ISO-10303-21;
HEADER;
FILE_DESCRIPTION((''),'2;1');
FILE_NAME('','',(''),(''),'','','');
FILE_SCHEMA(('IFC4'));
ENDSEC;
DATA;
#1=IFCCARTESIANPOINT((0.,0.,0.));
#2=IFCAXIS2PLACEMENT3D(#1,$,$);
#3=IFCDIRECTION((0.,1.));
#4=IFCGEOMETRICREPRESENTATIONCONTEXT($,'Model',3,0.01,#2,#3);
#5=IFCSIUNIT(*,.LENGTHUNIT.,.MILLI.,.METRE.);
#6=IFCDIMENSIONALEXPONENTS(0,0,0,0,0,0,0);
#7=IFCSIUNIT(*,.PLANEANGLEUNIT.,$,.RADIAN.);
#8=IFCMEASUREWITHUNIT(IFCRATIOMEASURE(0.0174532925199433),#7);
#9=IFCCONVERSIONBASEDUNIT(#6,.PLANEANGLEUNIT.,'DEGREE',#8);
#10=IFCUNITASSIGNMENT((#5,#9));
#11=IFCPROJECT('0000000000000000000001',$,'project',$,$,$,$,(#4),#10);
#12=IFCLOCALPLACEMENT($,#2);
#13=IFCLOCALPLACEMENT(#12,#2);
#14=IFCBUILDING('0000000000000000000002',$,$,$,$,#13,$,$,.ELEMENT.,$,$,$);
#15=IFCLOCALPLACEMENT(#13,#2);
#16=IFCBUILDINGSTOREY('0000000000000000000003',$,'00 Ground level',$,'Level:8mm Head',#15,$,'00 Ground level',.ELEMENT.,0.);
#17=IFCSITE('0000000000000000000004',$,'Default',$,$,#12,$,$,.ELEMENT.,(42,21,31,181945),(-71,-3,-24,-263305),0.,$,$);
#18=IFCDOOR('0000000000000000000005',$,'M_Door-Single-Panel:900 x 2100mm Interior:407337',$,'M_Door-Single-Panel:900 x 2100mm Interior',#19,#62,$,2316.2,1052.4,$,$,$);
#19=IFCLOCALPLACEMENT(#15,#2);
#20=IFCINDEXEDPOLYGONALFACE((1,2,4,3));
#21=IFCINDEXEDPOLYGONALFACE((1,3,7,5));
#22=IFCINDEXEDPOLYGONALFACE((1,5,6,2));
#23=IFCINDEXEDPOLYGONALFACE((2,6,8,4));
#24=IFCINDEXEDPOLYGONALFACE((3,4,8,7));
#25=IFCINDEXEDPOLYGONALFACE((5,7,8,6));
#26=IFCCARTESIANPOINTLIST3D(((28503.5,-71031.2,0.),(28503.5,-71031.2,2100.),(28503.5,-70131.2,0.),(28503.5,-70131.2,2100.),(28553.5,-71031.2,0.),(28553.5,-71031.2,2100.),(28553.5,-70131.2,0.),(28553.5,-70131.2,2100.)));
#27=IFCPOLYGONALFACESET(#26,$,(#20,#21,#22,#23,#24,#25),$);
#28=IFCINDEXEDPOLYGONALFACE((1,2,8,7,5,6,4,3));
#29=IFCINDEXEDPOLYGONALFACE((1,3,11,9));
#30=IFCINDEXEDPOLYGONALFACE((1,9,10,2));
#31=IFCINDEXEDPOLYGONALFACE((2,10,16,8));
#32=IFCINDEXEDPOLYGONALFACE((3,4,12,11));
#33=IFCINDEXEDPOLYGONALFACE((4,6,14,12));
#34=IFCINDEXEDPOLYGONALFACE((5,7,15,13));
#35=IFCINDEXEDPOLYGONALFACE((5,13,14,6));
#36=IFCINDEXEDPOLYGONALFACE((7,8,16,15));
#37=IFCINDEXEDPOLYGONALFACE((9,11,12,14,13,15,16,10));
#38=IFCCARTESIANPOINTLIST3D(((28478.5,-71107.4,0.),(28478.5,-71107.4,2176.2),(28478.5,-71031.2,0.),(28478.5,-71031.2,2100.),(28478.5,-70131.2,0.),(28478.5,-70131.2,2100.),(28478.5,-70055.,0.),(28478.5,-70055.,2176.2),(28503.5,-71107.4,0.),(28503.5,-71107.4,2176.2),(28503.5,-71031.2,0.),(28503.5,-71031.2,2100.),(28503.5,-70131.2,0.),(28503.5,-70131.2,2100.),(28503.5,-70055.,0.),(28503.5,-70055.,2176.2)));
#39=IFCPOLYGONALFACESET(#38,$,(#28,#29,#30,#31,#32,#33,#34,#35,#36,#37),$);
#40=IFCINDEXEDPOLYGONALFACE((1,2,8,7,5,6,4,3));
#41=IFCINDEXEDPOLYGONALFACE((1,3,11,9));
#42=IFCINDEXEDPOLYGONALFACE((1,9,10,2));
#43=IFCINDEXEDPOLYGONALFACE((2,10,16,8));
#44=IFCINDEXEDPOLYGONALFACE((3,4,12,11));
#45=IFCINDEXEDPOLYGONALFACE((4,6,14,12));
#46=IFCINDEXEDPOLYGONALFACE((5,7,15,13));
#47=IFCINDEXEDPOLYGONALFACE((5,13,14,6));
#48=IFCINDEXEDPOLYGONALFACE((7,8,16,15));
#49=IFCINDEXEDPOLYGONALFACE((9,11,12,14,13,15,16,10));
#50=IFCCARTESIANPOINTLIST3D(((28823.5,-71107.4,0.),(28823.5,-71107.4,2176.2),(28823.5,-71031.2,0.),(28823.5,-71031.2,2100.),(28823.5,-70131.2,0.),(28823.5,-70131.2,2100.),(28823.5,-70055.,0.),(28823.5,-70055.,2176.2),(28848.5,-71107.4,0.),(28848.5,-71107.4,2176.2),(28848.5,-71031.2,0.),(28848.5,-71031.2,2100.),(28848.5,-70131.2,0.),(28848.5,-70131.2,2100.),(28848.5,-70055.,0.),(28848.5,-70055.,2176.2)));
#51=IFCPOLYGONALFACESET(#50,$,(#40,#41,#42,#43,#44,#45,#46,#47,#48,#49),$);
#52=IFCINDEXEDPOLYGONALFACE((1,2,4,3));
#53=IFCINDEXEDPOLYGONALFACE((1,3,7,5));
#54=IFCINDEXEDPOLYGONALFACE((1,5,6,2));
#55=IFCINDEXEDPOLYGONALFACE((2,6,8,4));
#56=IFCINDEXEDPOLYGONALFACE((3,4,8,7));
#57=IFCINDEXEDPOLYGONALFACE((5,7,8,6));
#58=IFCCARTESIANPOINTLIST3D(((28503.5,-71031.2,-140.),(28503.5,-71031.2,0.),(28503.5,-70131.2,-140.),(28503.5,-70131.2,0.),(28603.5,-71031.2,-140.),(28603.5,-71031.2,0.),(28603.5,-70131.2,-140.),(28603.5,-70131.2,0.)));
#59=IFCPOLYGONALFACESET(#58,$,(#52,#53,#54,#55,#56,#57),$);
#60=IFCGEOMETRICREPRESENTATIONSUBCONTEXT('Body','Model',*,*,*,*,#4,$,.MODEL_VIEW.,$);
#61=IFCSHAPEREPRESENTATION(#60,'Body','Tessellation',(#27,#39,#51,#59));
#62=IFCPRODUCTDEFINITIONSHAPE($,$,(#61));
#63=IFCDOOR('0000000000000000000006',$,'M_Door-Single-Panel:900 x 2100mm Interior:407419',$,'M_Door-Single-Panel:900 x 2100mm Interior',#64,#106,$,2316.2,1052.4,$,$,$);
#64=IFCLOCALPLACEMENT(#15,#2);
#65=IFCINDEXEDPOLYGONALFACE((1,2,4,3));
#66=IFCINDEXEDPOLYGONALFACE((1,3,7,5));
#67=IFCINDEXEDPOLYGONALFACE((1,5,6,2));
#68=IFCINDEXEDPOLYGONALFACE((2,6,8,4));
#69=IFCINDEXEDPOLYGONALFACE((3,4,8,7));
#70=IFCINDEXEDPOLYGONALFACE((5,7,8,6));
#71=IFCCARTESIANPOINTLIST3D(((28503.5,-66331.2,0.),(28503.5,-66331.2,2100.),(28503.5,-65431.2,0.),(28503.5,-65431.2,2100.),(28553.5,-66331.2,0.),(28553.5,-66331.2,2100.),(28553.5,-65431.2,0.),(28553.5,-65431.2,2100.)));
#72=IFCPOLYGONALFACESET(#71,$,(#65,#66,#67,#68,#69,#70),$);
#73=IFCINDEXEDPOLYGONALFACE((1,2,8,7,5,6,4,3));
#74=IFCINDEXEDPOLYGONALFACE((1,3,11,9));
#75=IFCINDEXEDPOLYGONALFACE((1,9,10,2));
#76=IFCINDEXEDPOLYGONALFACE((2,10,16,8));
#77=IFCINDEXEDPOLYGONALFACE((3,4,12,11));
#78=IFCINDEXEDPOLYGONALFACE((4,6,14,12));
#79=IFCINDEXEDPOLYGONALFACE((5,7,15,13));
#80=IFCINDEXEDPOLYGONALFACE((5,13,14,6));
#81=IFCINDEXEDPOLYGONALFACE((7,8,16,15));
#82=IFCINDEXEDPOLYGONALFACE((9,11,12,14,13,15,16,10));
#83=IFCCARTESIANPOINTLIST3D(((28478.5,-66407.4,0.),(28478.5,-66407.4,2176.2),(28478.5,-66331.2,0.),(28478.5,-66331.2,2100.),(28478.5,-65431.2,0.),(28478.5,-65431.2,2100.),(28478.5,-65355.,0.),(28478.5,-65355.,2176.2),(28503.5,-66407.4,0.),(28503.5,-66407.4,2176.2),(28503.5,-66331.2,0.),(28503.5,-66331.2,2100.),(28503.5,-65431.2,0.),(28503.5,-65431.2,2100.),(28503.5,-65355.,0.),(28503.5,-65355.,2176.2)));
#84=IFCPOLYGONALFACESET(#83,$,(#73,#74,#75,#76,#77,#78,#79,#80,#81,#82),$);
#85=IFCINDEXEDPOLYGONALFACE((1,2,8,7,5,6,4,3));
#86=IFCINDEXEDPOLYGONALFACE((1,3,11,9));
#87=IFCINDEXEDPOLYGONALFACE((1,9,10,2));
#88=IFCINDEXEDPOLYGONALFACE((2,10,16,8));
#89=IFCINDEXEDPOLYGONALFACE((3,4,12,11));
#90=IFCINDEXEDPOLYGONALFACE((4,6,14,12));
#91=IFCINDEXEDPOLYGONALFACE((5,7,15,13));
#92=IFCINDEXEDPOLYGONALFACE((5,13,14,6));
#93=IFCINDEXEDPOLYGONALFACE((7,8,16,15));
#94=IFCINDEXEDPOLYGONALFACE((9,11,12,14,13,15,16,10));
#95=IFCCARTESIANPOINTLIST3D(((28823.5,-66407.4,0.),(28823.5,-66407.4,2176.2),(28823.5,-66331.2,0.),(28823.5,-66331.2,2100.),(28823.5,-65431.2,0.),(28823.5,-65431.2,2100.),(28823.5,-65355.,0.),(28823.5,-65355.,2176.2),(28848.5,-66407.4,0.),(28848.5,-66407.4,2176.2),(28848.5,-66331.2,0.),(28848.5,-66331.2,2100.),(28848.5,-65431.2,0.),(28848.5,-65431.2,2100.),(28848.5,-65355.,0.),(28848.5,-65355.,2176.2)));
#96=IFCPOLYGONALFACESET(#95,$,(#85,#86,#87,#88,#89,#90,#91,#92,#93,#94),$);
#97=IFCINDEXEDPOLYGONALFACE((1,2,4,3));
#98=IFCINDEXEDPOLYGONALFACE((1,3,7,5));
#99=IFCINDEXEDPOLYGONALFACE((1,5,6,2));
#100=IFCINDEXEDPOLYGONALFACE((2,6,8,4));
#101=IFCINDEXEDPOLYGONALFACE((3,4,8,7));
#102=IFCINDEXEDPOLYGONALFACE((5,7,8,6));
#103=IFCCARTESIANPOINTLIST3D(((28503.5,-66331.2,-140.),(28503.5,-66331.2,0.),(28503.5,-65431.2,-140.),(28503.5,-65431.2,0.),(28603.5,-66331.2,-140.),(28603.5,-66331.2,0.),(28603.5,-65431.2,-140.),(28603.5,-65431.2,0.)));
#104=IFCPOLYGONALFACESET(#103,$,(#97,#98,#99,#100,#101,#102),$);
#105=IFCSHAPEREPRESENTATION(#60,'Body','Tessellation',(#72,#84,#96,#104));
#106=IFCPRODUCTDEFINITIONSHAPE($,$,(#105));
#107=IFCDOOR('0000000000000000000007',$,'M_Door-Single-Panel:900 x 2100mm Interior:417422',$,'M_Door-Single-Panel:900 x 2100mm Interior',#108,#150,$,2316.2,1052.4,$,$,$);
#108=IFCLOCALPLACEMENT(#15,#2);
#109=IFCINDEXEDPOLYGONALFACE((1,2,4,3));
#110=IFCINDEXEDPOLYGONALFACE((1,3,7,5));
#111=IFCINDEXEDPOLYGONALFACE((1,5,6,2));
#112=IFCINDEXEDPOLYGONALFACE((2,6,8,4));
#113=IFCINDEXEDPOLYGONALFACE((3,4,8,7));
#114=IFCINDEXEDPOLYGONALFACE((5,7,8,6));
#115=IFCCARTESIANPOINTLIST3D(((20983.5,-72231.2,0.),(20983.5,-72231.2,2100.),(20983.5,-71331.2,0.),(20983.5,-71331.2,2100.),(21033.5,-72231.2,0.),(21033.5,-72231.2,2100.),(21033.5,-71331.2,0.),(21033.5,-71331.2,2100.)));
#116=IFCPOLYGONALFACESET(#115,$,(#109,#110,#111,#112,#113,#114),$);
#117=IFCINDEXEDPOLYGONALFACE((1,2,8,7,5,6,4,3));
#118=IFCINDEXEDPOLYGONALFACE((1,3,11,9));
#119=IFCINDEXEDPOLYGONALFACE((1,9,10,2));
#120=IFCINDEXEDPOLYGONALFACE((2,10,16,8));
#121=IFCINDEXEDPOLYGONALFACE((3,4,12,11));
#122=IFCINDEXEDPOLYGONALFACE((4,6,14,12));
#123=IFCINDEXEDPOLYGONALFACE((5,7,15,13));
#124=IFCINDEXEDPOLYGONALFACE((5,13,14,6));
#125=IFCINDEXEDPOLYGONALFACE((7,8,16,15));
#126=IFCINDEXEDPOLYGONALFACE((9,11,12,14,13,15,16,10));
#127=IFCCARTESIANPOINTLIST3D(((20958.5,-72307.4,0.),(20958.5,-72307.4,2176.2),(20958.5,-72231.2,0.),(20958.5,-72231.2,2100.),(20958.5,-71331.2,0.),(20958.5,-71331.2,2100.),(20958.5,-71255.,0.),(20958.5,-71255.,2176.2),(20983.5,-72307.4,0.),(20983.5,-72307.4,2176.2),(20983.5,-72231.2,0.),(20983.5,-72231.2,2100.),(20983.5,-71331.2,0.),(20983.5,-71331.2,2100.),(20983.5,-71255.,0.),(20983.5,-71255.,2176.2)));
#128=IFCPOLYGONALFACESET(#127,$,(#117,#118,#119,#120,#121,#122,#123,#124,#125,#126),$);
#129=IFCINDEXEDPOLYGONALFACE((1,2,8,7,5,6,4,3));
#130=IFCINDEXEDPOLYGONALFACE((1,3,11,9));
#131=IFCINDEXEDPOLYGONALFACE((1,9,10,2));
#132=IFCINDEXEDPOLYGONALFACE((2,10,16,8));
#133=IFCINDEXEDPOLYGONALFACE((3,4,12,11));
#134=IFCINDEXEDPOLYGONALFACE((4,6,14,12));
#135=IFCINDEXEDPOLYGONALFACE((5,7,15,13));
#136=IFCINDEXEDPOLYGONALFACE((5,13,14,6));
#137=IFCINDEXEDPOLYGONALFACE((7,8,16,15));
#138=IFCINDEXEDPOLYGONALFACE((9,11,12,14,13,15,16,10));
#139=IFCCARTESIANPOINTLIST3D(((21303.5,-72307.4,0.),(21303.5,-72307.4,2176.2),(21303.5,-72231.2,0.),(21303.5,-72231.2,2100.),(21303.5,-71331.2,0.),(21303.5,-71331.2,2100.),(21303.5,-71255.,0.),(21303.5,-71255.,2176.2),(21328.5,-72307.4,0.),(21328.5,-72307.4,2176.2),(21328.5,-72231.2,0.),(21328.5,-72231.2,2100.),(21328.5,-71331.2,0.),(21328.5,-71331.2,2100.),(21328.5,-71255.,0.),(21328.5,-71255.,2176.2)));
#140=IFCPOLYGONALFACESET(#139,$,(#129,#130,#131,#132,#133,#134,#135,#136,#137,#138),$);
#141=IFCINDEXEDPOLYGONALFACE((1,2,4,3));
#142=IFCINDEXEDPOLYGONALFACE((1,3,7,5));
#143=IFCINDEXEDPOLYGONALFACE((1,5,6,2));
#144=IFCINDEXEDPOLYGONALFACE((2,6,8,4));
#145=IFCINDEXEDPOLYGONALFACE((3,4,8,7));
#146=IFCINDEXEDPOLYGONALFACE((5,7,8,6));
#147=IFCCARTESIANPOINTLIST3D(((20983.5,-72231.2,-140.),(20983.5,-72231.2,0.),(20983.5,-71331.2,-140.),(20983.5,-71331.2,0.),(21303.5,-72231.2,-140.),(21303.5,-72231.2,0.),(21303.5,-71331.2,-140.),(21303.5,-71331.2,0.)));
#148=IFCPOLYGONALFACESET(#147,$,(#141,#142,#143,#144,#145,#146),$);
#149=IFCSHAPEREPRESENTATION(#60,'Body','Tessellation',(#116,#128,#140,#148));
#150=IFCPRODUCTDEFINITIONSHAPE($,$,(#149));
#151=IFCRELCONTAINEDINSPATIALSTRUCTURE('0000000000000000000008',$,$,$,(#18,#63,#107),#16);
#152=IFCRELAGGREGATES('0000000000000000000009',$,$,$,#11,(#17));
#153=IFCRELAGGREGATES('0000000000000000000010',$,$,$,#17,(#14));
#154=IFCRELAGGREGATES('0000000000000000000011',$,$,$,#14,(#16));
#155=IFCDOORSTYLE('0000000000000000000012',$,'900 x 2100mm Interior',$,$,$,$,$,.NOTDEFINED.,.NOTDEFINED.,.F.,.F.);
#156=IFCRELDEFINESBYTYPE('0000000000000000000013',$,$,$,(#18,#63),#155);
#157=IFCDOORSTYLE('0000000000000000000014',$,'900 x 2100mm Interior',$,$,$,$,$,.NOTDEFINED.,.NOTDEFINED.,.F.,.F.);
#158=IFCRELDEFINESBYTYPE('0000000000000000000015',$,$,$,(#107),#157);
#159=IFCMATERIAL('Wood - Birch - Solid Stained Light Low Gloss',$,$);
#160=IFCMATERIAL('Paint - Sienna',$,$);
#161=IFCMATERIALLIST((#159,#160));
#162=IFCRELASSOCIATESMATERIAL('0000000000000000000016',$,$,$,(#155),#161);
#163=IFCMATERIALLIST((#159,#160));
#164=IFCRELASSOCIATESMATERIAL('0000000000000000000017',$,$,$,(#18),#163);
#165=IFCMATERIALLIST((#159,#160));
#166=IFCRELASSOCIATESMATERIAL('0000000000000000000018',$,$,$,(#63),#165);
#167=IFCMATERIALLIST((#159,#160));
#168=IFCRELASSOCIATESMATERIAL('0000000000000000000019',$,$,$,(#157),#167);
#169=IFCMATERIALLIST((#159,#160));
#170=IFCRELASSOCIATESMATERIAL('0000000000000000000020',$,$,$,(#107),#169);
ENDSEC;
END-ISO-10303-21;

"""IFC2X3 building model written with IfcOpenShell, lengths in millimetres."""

from ifc_helpers import new_model, entity, si_unit, converted_unit, direction, frame, frame_2d, origin, origin_2d_with_axis, place, context, subcontext, project, spatial, polyline, rectangle, outline, extrude, source, transform, mapped, material, material_list, type_object, type_shapes, element, save


model = new_model("IFC2X3")

# Units and contexts
model_context = context("Model", 3, precision=0.01, world=origin(), true_north=direction((0.0, 1.0)))
body_context = subcontext(model_context, "Body", "Model", "MODEL_VIEW")
ifc_project = project(units=[si_unit("LENGTHUNIT", "METRE", prefix="MILLI"), converted_unit("PLANEANGLEUNIT", "DEGREE", entity("IfcRatioMeasure", 0.0174532925199433), si_unit("PLANEANGLEUNIT", "RADIAN"), dimensions=[0, 0, 0, 0, 0, 0, 0])], contexts=[model_context])

# Site, building, storey
site_placement = place(None, origin())
site = spatial("IfcSite", under=ifc_project, at=site_placement, Name="Default", CompositionType="ELEMENT", RefLatitude=(42, 21, 31, 181945), RefLongitude=(-71, -3, -24, -263305), RefElevation=0.0)
building_placement = place(site_placement, origin())
building = spatial("IfcBuilding", under=site, at=building_placement, CompositionType="ELEMENT")
storey_placement = place(building_placement, origin())
storey = spatial("IfcBuildingStorey", under=building, at=storey_placement, Name="00 Ground level", ObjectType="Level:8mm Head", LongName="00 Ground level", CompositionType="ELEMENT", Elevation=0.0)

# Doors
ifc_material_1 = material(Name="Wood - Birch - Solid Stained Light Low Gloss")
ifc_material_2 = material(Name="Paint - Sienna")
ifc_material_list_1 = material_list([ifc_material_1, ifc_material_2])
ifc_material_list_2 = material_list([ifc_material_1, ifc_material_2])
door_style_1 = type_object("IfcDoorStyle", Name="900 x 2100mm Interior", ConstructionType="NOTDEFINED", OperationType="NOTDEFINED", ParameterTakesPrecedence=False, Sizeable=False, material=ifc_material_list_2)
shared_shape_1 = source(origin(), body_context, "Body", "SweptSolid", [
    extrude(rectangle(XDim=900.0, YDim=50.0, at=origin_2d_with_axis()), frame((450.0, 295.0, 140.0)), (0.0, 0.0, 1.0), 2100.0),
    extrude(outline(polyline([(-526.2, -1107.2), (526.2, -1107.2), (526.2, 1069.0), (450.0, 1069.0), (450.0, -1031.0), (-450.0, -1031.0), (-450.0, 1069.0), (-526.2, 1069.0), (-526.2, -1107.2)])), frame((450.0, 345.0, 1209.0), z_axis=(0.0, -1.0, 0.0), x_axis=(-1.0, 0.0, 0.0)), (0.0, 0.0, 1.0), 25.0),
    extrude(outline(polyline([(-1107.2, -526.2), (1069.0, -526.2), (1069.0, -450.0), (-1031.0, -450.0), (-1031.0, 450.0), (1069.0, 450.0), (1069.0, 526.2), (-1107.2, 526.2), (-1107.2, -526.2)])), frame((450.0, 0.0, 1209.0), z_axis=(0.0, -1.0, 0.0), x_axis=(0.0, 0.0, -1.0)), (0.0, 0.0, 1.0), 25.0),
    extrude(rectangle(XDim=100.0, YDim=900.0, at=frame_2d((0.0, 0.0), x_axis=(1.0, 0.0))), frame((450.0, 270.0, 0.0), z_axis=(0.0, 0.0, 1.0), x_axis=(0.0, -1.0, 0.0)), (0.0, 0.0, 1.0), 140.0),
])
type_shapes(door_style_1, [shared_shape_1])
door_1_placement = place(storey_placement, frame((28823.5, -71031.2, -140.0), z_axis=(0.0, 0.0, 1.0), x_axis=(0.0, 1.0, 0.0)))
element("IfcDoor", 1, at=door_1_placement, inside=storey, type_object=door_style_1, material=ifc_material_list_1, Name="M_Door-Single-Panel:900 x 2100mm Interior:407337", ObjectType="M_Door-Single-Panel:900 x 2100mm Interior", OverallHeight=2316.2, OverallWidth=1052.4, context=body_context, shape_type="MappedRepresentation", body=[
    mapped(shared_shape_1, transform((0.0, 0.0, 0.0), scale=1.0)),
])
ifc_material_list_3 = material_list([ifc_material_1, ifc_material_2])
door_2_placement = place(storey_placement, frame((28823.5, -66331.2, -140.0), z_axis=(0.0, 0.0, 1.0), x_axis=(0.0, 1.0, 0.0)))
element("IfcDoor", 2, at=door_2_placement, inside=storey, type_object=door_style_1, material=ifc_material_list_3, Name="M_Door-Single-Panel:900 x 2100mm Interior:407419", ObjectType="M_Door-Single-Panel:900 x 2100mm Interior", OverallHeight=2316.2, OverallWidth=1052.4, context=body_context, shape_type="MappedRepresentation", body=[
    mapped(shared_shape_1, transform((0.0, 0.0, 0.0), scale=1.0)),
])
ifc_material_list_4 = material_list([ifc_material_1, ifc_material_2])
ifc_material_list_5 = material_list([ifc_material_1, ifc_material_2])
door_style_2 = type_object("IfcDoorStyle", Name="900 x 2100mm Interior", ConstructionType="NOTDEFINED", OperationType="NOTDEFINED", ParameterTakesPrecedence=False, Sizeable=False, material=ifc_material_list_5)
shared_shape_2 = source(origin(), body_context, "Body", "SweptSolid", [
    extrude(rectangle(XDim=50.0, YDim=900.0, at=origin_2d_with_axis()), frame((450.0, 295.0, 140.0), z_axis=(0.0, 0.0, 1.0), x_axis=(0.0, 1.0, 0.0)), (0.0, 0.0, 1.0), 2100.0),
    extrude(outline(polyline([(-526.2, -1107.2), (526.2, -1107.2), (526.2, 1069.0), (450.0, 1069.0), (450.0, -1031.0), (-450.0, -1031.0), (-450.0, 1069.0), (-526.2, 1069.0), (-526.2, -1107.2)])), frame((450.0, 320.0, 1209.0), z_axis=(0.0, 1.0, 0.0), x_axis=(1.0, 0.0, 0.0)), (0.0, 0.0, 1.0), 25.0),
    extrude(outline(polyline([(-1107.2, -526.2), (1069.0, -526.2), (1069.0, -450.0), (-1031.0, -450.0), (-1031.0, 450.0), (1069.0, 450.0), (1069.0, 526.2), (-1107.2, 526.2), (-1107.2, -526.2)])), frame((450.0, -25.0, 1209.0), z_axis=(0.0, 1.0, 0.0), x_axis=(0.0, 0.0, -1.0)), (0.0, 0.0, 1.0), 25.0),
    extrude(rectangle(XDim=900.0, YDim=320.0, at=frame_2d((0.0, 0.0), x_axis=(1.0, 0.0))), frame((450.0, 160.0, 0.0), z_axis=(0.0, 0.0, 1.0), x_axis=(-1.0, 0.0, 0.0)), (0.0, 0.0, 1.0), 140.0),
])
type_shapes(door_style_2, [shared_shape_2])
door_3_placement = place(storey_placement, frame((21303.5, -72231.2, -140.0), z_axis=(0.0, 0.0, 1.0), x_axis=(0.0, 1.0, 0.0)))
element("IfcDoor", 3, at=door_3_placement, inside=storey, type_object=door_style_2, material=ifc_material_list_4, Name="M_Door-Single-Panel:900 x 2100mm Interior:417422", ObjectType="M_Door-Single-Panel:900 x 2100mm Interior", OverallHeight=2316.2, OverallWidth=1052.4, context=body_context, shape_type="MappedRepresentation", body=[
    mapped(shared_shape_2, transform((0.0, 0.0, 0.0), scale=1.0)),
])

save(model, "model.ifc")
